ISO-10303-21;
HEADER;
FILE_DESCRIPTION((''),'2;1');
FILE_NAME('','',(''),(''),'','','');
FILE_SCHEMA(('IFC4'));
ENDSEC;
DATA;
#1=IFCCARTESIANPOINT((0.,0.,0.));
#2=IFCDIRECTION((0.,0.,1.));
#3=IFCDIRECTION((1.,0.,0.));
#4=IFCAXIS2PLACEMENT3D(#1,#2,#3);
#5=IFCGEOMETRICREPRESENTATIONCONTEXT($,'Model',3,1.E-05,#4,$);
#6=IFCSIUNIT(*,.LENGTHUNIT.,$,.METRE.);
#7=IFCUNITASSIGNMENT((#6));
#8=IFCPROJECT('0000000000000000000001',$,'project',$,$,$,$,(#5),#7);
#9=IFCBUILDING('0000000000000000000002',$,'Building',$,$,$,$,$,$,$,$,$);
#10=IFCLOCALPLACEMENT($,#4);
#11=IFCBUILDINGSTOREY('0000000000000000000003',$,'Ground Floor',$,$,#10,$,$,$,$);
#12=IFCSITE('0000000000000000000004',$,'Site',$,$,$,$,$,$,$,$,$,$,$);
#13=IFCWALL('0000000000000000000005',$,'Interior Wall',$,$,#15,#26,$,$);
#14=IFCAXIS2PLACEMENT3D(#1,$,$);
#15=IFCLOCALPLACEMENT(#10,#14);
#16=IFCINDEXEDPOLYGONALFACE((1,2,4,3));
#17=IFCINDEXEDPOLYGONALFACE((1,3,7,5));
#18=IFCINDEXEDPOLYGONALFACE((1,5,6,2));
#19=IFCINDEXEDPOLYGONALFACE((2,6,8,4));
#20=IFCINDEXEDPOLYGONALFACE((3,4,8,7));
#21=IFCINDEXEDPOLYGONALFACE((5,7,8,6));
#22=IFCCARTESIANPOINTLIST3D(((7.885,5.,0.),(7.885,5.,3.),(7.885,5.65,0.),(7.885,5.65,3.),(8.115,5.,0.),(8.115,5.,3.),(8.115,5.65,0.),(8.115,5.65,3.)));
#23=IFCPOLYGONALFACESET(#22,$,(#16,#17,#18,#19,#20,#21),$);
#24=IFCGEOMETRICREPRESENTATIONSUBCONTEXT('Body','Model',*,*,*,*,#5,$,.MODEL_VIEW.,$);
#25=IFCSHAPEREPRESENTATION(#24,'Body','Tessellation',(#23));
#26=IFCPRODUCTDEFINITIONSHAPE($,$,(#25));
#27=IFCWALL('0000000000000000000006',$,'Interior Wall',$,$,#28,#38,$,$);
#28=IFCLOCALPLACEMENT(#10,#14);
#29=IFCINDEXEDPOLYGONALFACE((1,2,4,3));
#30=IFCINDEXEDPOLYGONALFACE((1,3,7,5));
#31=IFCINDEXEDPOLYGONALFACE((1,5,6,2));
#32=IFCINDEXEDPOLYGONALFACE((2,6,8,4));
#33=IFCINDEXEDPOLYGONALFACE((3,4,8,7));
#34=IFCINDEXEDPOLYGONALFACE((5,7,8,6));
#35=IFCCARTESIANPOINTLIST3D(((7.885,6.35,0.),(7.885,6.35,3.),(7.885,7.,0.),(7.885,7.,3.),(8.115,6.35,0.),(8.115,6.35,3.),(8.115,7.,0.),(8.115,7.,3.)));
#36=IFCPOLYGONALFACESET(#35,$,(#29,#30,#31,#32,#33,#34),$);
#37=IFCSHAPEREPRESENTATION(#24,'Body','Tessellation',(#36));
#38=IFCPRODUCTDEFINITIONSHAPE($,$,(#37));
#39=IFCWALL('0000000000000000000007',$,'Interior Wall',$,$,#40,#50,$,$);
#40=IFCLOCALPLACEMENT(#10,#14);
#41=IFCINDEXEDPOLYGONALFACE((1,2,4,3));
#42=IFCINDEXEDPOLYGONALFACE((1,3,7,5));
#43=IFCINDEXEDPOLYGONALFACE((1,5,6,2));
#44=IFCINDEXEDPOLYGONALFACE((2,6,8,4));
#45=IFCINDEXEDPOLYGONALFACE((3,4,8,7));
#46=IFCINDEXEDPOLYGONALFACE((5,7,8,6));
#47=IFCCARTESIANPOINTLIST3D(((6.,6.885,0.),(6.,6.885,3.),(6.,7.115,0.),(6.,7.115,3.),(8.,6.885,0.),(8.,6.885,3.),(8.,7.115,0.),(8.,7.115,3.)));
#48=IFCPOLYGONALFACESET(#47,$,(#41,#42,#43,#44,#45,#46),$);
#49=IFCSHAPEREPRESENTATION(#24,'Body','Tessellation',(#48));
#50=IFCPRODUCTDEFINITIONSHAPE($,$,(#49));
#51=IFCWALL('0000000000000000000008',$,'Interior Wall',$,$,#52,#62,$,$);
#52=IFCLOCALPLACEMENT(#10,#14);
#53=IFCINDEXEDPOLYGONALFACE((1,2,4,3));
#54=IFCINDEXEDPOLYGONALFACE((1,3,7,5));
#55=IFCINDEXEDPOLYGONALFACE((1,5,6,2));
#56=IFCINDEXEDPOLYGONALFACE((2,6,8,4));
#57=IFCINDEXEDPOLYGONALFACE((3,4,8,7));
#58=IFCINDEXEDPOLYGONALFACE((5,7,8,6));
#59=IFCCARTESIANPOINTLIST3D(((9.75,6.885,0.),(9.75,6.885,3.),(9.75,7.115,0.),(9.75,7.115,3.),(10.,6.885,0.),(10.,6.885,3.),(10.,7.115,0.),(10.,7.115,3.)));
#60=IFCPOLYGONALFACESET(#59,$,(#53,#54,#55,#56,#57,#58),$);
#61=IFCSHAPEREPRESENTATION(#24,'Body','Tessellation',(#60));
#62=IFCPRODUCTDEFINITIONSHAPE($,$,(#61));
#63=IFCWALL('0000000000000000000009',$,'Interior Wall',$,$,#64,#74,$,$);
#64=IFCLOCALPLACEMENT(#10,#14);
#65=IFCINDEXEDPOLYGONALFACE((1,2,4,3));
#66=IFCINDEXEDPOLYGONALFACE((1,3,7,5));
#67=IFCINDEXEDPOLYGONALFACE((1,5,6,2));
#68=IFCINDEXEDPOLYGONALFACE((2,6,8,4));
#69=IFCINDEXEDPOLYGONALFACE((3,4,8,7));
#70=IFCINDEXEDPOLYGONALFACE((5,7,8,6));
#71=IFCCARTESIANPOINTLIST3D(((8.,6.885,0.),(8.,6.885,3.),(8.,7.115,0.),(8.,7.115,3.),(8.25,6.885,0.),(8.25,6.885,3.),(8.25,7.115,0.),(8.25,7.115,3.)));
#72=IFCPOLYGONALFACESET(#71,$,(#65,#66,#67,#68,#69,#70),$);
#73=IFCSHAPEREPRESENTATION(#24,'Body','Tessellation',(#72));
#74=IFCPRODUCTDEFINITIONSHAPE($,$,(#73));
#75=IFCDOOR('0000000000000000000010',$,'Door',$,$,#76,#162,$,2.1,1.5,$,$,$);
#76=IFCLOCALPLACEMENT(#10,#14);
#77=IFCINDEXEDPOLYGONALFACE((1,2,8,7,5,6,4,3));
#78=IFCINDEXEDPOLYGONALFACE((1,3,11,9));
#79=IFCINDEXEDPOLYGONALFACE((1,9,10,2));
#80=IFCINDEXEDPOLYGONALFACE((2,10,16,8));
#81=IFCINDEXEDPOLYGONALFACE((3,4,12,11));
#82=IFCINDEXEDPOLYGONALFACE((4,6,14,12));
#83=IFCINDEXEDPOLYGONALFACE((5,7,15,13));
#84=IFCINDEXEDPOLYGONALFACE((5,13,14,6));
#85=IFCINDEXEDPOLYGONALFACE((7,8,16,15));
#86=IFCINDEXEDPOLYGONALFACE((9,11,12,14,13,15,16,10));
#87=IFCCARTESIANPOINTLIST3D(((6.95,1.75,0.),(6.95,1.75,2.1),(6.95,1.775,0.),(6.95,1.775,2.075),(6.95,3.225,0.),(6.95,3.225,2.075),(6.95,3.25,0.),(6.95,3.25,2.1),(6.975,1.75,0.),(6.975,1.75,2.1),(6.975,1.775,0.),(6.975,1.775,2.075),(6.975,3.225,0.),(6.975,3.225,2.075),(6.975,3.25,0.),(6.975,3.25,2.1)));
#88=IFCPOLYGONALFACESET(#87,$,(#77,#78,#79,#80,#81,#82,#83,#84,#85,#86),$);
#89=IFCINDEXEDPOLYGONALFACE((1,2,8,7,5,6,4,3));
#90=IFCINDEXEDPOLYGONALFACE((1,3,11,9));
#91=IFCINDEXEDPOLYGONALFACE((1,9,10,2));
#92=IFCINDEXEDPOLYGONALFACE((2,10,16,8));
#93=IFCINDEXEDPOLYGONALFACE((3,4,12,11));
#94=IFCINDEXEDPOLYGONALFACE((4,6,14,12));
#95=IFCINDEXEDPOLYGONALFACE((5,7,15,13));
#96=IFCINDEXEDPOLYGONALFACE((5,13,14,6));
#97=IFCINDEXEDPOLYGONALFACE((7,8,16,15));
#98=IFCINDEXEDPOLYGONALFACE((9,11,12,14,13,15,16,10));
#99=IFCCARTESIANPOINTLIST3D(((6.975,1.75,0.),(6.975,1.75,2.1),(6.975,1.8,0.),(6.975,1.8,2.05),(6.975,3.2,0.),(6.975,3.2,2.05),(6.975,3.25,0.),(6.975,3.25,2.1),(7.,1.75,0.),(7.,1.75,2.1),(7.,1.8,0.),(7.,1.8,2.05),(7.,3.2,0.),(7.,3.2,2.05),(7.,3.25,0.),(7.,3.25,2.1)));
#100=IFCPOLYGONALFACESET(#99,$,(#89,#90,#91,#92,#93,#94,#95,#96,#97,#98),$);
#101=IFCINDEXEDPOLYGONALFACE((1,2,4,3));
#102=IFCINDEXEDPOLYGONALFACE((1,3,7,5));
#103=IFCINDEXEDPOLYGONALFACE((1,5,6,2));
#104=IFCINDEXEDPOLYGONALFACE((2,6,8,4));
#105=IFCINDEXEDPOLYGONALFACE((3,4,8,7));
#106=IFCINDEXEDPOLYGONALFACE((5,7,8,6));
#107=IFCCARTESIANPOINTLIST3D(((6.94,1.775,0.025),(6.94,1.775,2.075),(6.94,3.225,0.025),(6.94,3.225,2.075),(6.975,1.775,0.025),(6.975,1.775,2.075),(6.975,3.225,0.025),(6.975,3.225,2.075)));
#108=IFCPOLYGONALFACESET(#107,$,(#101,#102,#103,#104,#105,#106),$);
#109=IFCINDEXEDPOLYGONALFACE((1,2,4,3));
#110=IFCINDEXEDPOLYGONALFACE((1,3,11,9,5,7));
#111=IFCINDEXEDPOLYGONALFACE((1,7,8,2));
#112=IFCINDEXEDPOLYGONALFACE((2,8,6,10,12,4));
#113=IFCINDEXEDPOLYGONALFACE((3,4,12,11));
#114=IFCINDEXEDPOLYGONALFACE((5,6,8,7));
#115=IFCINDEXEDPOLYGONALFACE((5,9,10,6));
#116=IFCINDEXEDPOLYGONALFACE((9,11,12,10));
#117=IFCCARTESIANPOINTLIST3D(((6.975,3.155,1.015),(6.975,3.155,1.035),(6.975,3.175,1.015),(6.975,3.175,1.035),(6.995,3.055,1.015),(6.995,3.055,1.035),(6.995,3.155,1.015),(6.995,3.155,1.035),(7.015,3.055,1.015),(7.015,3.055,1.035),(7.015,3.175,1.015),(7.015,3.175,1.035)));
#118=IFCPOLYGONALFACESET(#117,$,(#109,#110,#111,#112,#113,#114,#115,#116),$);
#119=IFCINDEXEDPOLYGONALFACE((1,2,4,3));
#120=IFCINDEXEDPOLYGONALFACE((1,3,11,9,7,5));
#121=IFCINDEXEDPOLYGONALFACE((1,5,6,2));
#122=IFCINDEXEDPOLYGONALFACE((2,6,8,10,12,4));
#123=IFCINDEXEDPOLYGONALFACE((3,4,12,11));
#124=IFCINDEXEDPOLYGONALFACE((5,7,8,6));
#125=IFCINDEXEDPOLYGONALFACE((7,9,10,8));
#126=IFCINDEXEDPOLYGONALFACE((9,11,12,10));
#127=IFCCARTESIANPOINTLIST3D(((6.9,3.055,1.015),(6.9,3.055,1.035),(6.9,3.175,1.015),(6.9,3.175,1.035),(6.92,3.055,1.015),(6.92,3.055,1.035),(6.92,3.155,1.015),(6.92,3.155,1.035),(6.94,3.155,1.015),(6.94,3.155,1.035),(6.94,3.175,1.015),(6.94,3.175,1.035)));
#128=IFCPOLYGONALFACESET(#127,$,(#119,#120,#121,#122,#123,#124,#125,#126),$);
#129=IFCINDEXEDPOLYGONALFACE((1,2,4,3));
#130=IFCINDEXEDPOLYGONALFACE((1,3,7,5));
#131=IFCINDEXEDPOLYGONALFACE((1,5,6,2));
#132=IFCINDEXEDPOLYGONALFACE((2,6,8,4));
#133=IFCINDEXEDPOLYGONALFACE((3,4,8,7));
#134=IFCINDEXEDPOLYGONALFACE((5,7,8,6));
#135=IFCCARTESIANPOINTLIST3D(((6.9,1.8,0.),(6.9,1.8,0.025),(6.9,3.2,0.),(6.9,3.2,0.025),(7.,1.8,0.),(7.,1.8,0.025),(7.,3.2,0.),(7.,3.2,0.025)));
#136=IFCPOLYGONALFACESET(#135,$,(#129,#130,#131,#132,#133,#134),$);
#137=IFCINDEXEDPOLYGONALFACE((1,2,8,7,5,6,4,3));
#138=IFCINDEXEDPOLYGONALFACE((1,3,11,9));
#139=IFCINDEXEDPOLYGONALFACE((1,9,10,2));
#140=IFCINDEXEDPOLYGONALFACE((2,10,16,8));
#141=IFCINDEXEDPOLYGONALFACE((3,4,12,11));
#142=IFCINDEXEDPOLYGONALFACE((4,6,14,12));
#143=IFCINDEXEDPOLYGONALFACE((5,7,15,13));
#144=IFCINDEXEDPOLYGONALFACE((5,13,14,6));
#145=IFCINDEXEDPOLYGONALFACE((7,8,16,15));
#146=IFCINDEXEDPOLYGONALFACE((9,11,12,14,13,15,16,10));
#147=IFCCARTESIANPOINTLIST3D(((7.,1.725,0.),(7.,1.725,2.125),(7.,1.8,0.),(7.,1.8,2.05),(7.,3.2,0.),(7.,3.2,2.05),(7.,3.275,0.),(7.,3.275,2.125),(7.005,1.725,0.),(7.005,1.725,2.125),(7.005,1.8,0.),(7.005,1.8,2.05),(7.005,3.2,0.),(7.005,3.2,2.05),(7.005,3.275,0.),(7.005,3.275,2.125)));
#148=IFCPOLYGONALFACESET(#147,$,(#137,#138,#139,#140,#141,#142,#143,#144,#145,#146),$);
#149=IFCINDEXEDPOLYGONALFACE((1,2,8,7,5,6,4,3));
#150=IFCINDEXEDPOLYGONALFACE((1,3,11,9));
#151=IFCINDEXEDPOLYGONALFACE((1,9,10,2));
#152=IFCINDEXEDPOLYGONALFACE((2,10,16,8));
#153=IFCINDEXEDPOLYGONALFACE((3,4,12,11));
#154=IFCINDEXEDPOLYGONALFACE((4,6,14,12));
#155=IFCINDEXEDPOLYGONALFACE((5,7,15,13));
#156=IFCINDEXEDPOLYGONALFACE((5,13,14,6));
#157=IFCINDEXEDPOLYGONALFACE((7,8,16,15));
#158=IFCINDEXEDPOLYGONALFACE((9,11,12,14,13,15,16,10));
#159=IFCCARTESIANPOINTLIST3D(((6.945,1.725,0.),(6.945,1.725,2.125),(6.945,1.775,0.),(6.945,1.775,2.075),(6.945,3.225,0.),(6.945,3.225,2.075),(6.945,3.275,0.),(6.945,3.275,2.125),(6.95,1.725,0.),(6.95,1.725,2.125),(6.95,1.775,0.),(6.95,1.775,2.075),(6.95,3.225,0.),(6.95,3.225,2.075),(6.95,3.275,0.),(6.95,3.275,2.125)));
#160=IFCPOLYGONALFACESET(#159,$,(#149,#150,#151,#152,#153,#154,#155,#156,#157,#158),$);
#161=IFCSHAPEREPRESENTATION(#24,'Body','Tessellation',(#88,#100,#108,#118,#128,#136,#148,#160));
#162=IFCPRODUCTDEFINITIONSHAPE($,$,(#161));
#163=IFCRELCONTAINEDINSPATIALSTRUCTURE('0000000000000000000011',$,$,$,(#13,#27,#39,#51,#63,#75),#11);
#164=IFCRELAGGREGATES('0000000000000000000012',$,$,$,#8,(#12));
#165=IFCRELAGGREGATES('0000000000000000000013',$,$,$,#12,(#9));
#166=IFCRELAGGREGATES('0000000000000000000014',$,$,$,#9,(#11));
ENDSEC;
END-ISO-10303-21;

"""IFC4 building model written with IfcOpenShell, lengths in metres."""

from ifc_helpers import new_model, si_unit, frame, origin_with_axes, place, context, subcontext, project, spatial, line, indexed_curve, outline, extrude, element, save


model = new_model("IFC4")

# Units and contexts
model_context = context("Model", 3, precision=1e-05, world=origin_with_axes())
body_context = subcontext(model_context, "Body", "Model", "MODEL_VIEW")
ifc_project = project(units=[si_unit("LENGTHUNIT", "METRE")], contexts=[model_context])

# Site, building, storey
site = spatial("IfcSite", under=ifc_project, Name="Site")
building = spatial("IfcBuilding", under=site, Name="Building")
storey_placement = place(None, origin_with_axes())
storey = spatial("IfcBuildingStorey", under=building, at=storey_placement, Name="Ground Floor")

# Walls
for number, where, z_axis, x_axis, name in (
    (1, (8.0, 5.0, 0.0), (0.0, 0.0, 1.0), (0.0, 1.0, 0.0), "Interior Wall"),
    (2, (8.0, 6.35, 0.0), (0.0, 0.0, 1.0), (0.0, 1.0, 0.0), "Interior Wall"),
):
    element("IfcWall", number, at=place(storey_placement, frame(where, z_axis=z_axis, x_axis=x_axis)), inside=storey, Name=name, context=body_context, shape_type="SweptSolid", body=[
        extrude(outline(indexed_curve([(0.0, 0.0), (0.0, 0.23), (0.65, 0.23), (0.65, 0.0), (0.0, 0.0)], self_intersect=False)), frame((0.0, -0.115, 0.0), z_axis=(0.0, 0.0, 1.0), x_axis=(1.0, 0.0, 0.0)), (0.0, 0.0, 1.0), 3.0),
    ])
wall_1_placement = place(storey_placement, frame((8.0, 7.0, 0.0), z_axis=(0.0, 0.0, 1.0), x_axis=(-1.0, 0.0, 0.0)))
element("IfcWall", 3, at=wall_1_placement, inside=storey, Name="Interior Wall", context=body_context, shape_type="SweptSolid", body=[
    extrude(outline(indexed_curve([(0.0, 0.0), (0.0, 0.23), (2.0, 0.23), (2.0, 0.0), (0.0, 0.0)], self_intersect=False)), frame((0.0, -0.115, 0.0), z_axis=(0.0, 0.0, 1.0), x_axis=(1.0, 0.0, 0.0)), (0.0, 0.0, 1.0), 3.0),
])
for number, where, z_axis, x_axis, name in (
    (4, (10.0, 7.0, 0.0), (0.0, 0.0, 1.0), (-1.0, 0.0, 0.0), "Interior Wall"),
    (5, (8.25, 7.0, 0.0), (0.0, 0.0, 1.0), (-1.0, 0.0, 0.0), "Interior Wall"),
):
    element("IfcWall", number, at=place(storey_placement, frame(where, z_axis=z_axis, x_axis=x_axis)), inside=storey, Name=name, context=body_context, shape_type="SweptSolid", body=[
        extrude(outline(indexed_curve([(0.0, 0.0), (0.0, 0.23), (0.25, 0.23), (0.25, 0.0), (0.0, 0.0)], self_intersect=False)), frame((0.0, -0.115, 0.0), z_axis=(0.0, 0.0, 1.0), x_axis=(1.0, 0.0, 0.0)), (0.0, 0.0, 1.0), 3.0),
    ])

# Door
door_1_placement = place(storey_placement, frame((7.0, 1.75, 0.0), z_axis=(0.0, 0.0, 1.0), x_axis=(0.0, 1.0, 0.0)))
element("IfcDoor", 6, at=door_1_placement, inside=storey, Name="Door", OverallHeight=2.1, OverallWidth=1.5, context=body_context, shape_type="SweptSolid", body=[
    extrude(outline(indexed_curve([(0.0, 0.0), (0.0, 2.1), (1.5, 2.1), (1.5, 0.0), (1.475, 0.0), (1.475, 2.075), (0.025, 2.075), (0.025, 0.0)], segments=[line(1, 2, 3, 4, 5, 6, 7, 8, 1)])), frame((0.0, 0.025, 0.0), z_axis=(0.0, -1.0, 0.0), x_axis=(1.0, 0.0, 0.0)), (0.0, 0.0, -1.0), 0.025),
    extrude(outline(indexed_curve([(0.0, 0.0), (0.0, 2.1), (1.5, 2.1), (1.5, 0.0), (1.45, 0.0), (1.45, 2.05), (0.05, 2.05), (0.05, 0.0)], segments=[line(1, 2, 3, 4, 5, 6, 7, 8, 1)])), frame((0.0, 0.0, 0.0), z_axis=(0.0, -1.0, 0.0), x_axis=(1.0, 0.0, 0.0)), (0.0, 0.0, -1.0), 0.025),
    extrude(outline(indexed_curve([(0.0, 0.0), (1.45, 0.0), (1.45, 0.035), (0.0, 0.035)], segments=[line(1, 2, 3, 4, 1)])), frame((0.025, 0.025, 0.025), z_axis=(0.0, 0.0, 1.0), x_axis=(1.0, 0.0, 0.0)), (0.0, 0.0, 1.0), 2.05),
    extrude(outline(indexed_curve([(0.0, 0.0), (0.0, -0.04), (-0.12, -0.04), (-0.12, -0.02), (-0.02, -0.02), (-0.02, 0.0)], segments=[line(1, 2, 3, 4, 5, 6, 1)])), frame((1.425, 0.025, 1.015), z_axis=(0.0, 0.0, 1.0), x_axis=(1.0, 0.0, 0.0)), (0.0, 0.0, 1.0), 0.02),
    extrude(outline(indexed_curve([(0.0, 0.0), (0.0, 0.04), (-0.12, 0.04), (-0.12, 0.02), (-0.02, 0.02), (-0.02, 0.0)], segments=[line(1, 2, 3, 4, 5, 6, 1)])), frame((1.425, 0.06, 1.015), z_axis=(0.0, 0.0, 1.0), x_axis=(1.0, 0.0, 0.0)), (0.0, 0.0, 1.0), 0.02),
    extrude(outline(indexed_curve([(0.0, 0.0), (1.4, 0.0), (1.4, 0.1), (0.0, 0.1)], segments=[line(1, 2, 3, 4, 1)])), frame((0.05, 0.0, 0.0), z_axis=(0.0, 0.0, 1.0), x_axis=(1.0, 0.0, 0.0)), (0.0, 0.0, 1.0), 0.025),
    extrude(outline(indexed_curve([(0.0, 0.0), (0.0, 2.125), (1.55, 2.125), (1.55, 0.0), (1.475, 0.0), (1.475, 2.05), (0.075, 2.05), (0.075, 0.0)], segments=[line(1, 2, 3, 4, 5, 6, 7, 8, 1)])), frame((-0.025, -0.005, 0.0), z_axis=(0.0, -1.0, 0.0), x_axis=(1.0, 0.0, 0.0)), (0.0, 0.0, -1.0), 0.005),
    extrude(outline(indexed_curve([(0.0, 0.0), (0.0, 2.125), (1.55, 2.125), (1.55, 0.0), (1.5, 0.0), (1.5, 2.075), (0.05, 2.075), (0.05, 0.0)], segments=[line(1, 2, 3, 4, 5, 6, 7, 8, 1)])), frame((-0.025, 0.05, 0.0), z_axis=(0.0, -1.0, 0.0), x_axis=(1.0, 0.0, 0.0)), (0.0, 0.0, -1.0), 0.005),
])

save(model, "model.ifc")
